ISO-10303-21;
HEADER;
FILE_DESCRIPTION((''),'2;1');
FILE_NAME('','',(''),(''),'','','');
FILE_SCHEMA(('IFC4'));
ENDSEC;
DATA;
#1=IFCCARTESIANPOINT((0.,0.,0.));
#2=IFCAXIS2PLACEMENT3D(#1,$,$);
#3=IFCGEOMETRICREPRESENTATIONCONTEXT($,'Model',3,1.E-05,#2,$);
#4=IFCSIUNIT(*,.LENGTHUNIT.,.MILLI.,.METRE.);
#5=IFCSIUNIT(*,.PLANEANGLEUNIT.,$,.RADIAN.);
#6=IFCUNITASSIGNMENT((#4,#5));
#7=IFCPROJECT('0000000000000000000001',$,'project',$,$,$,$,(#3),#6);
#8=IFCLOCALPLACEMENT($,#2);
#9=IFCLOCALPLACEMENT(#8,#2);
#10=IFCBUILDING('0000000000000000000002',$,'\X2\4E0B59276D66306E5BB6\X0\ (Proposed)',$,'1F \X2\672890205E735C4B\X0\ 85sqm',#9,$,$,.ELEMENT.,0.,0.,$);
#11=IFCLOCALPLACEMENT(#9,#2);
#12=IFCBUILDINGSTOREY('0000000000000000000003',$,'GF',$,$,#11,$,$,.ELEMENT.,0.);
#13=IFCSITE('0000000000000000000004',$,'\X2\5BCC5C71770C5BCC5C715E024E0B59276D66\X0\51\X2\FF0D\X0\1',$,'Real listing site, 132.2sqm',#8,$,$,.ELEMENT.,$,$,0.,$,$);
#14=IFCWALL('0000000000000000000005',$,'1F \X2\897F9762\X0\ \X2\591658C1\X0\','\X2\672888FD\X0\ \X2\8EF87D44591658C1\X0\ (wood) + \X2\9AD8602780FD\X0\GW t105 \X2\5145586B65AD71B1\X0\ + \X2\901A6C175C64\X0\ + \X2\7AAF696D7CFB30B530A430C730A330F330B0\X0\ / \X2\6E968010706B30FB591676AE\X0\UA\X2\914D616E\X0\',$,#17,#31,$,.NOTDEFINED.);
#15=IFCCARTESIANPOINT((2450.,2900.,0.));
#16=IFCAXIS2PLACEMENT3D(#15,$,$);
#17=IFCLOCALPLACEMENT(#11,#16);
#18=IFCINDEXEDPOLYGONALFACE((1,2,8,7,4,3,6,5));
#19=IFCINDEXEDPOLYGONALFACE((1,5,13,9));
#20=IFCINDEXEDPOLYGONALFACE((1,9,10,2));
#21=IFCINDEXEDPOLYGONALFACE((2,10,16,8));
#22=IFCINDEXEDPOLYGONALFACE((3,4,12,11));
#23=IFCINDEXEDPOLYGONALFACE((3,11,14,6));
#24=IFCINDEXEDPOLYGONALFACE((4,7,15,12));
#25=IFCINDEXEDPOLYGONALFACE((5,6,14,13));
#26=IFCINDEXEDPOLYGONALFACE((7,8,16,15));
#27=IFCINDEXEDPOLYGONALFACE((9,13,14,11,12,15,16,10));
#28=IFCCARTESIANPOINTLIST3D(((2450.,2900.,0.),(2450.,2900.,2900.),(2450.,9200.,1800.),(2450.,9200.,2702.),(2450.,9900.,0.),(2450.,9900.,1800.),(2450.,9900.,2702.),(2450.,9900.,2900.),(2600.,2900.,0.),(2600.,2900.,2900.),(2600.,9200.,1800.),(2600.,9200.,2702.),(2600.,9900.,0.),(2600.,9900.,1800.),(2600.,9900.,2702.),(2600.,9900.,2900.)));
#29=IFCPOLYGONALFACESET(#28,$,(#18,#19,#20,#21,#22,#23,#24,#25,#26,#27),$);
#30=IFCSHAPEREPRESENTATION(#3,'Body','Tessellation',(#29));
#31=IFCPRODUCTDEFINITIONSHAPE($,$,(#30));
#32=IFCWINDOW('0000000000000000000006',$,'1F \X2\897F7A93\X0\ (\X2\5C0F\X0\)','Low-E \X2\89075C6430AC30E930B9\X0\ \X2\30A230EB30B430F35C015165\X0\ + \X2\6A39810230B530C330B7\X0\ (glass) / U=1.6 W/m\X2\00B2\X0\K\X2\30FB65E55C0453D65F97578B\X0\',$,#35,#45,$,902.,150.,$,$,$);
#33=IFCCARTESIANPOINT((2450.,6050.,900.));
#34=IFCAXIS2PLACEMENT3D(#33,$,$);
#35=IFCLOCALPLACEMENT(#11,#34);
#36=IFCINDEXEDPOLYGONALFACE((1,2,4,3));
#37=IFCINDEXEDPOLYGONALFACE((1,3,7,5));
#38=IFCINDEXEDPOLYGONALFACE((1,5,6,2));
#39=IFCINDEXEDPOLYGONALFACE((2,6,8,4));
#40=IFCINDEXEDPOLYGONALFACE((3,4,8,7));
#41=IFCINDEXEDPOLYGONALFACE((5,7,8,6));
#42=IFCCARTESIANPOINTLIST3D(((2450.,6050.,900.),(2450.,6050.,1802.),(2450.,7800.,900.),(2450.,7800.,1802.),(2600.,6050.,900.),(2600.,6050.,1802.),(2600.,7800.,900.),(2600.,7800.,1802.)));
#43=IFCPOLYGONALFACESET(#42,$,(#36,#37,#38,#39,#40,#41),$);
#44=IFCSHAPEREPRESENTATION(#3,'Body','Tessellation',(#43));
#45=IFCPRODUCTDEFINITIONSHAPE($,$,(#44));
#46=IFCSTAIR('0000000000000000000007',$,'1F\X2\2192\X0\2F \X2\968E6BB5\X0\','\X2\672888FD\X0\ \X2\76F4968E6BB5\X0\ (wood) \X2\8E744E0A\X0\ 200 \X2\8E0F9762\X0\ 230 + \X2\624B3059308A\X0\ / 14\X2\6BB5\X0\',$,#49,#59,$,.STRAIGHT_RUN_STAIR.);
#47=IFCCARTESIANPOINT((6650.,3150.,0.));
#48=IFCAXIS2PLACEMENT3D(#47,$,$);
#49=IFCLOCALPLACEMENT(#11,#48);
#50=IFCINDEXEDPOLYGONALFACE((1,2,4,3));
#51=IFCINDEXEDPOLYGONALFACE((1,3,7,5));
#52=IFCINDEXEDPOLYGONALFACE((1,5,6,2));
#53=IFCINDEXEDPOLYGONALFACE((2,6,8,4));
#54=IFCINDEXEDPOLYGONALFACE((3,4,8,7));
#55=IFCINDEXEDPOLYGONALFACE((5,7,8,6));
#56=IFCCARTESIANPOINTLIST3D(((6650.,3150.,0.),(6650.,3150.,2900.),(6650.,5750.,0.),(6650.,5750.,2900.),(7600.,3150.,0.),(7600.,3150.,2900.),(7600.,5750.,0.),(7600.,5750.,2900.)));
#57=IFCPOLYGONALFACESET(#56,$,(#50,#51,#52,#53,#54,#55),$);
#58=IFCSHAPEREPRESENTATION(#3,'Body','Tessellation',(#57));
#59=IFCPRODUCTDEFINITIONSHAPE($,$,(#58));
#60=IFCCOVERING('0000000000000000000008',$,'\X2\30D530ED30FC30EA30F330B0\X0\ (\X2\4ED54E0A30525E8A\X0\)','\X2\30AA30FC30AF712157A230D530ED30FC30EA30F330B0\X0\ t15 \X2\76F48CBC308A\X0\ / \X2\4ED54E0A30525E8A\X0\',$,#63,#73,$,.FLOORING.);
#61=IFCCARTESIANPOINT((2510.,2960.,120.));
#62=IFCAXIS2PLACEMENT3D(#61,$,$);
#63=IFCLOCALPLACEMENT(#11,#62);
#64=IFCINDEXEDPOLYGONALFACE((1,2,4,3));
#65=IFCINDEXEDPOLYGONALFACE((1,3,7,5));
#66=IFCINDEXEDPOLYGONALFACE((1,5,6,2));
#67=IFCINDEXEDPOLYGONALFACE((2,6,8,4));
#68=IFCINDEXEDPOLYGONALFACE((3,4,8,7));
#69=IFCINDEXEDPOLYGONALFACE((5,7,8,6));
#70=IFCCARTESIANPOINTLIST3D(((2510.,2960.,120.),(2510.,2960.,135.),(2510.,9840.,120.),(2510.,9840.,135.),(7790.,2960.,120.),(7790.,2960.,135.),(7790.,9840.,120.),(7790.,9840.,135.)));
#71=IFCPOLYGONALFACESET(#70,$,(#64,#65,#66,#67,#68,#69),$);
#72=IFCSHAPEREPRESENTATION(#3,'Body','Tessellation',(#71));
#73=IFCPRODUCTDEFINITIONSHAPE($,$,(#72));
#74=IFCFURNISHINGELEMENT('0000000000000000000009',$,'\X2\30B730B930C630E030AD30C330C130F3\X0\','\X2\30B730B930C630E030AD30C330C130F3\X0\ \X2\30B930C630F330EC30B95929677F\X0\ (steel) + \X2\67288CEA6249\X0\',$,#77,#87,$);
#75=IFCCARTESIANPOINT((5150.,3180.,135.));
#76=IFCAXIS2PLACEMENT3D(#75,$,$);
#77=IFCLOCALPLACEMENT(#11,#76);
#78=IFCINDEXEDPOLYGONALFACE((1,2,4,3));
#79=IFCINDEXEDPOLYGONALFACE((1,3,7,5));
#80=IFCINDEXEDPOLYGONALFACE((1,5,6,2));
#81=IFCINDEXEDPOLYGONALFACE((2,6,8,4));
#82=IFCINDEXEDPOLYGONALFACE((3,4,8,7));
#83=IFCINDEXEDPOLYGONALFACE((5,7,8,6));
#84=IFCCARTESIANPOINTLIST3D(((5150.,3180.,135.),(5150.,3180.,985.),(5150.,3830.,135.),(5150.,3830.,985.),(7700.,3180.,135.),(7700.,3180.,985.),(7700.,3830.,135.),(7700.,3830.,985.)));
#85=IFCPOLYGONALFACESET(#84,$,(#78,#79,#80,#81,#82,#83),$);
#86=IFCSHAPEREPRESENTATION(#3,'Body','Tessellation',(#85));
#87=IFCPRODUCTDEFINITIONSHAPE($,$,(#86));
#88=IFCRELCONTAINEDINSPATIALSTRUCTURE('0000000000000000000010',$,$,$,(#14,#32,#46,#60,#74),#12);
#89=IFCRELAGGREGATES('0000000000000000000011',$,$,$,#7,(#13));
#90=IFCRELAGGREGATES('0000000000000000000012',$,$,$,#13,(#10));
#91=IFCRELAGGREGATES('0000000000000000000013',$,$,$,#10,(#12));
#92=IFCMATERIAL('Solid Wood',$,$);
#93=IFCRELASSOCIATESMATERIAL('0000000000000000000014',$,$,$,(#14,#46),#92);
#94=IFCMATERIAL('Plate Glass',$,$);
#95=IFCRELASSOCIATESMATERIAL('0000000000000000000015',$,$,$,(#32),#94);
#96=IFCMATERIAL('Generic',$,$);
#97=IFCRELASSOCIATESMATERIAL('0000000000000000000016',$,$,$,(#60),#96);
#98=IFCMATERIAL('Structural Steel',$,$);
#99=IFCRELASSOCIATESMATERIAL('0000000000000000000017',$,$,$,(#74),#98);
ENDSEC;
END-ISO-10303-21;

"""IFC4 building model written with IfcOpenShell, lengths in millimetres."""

from ifc_helpers import new_model, si_unit, frame, frame_2d, origin, place, context, project, spatial, rectangle, extrude, material, element, fill, save


model = new_model("IFC4")

# Units and contexts
model_context = context("Model", 3, precision=1e-05, world=origin())
ifc_project = project(units=[si_unit("LENGTHUNIT", "METRE", prefix="MILLI"), si_unit("PLANEANGLEUNIT", "RADIAN")], contexts=[model_context])

# Site, building, storey
site_placement = place(None, origin())
site = spatial("IfcSite", under=ifc_project, at=site_placement, Name="富山県富山市下大浦51－1", ObjectType="Real listing site, 132.2sqm", CompositionType="ELEMENT", RefElevation=0.0)
building_placement = place(site_placement, origin())
building = spatial("IfcBuilding", under=site, at=building_placement, Name="下大浦の家 (Proposed)", ObjectType="1F 木造平屋 85sqm", CompositionType="ELEMENT", ElevationOfRefHeight=0.0, ElevationOfTerrain=0.0)
storey_placement = place(building_placement, origin())
storey = spatial("IfcBuildingStorey", under=building, at=storey_placement, Name="GF", CompositionType="ELEMENT", Elevation=0.0)

# Shared definitions
ifc_material_1 = material(Name="Solid Wood")
ifc_material_2 = material(Name="Generic")

# Shared definitions
ifc_material_3 = material(Name="Plate Glass")

# Wall, opening, window
wall_1_placement = place(storey_placement, frame((2450.0, 2900.0, 0.0)))
wall_1 = element("IfcWall", 1, at=wall_1_placement, inside=storey, material=ifc_material_1, Name="1F 西面 外壁", Description="木製 軸組外壁 (wood) + 高性能GW t105 充填断熱 + 通気層 + 窯業系サイディング / 準耐火・外皮UA配慮", PredefinedType="NOTDEFINED", context=model_context, shape_type="SweptSolid", body=[
    extrude(rectangle(XDim=150.0, YDim=7000.0, at=frame_2d((75.0, 3500.0))), frame((2450.0, 2900.0, 0.0)), (0.0, 0.0, 1.0), 2900.0),
])
opening_1_placement = place(storey_placement, frame((2450.0, 6050.0, 900.0)))
opening_1 = element("IfcOpeningElement", 2, at=opening_1_placement, cuts=wall_1, PredefinedType="NOTDEFINED", context=model_context, shape_type="SweptSolid", body=[
    extrude(rectangle(XDim=150.0, YDim=1750.0, at=frame_2d((75.0, 875.0))), frame((2450.0, 6050.0, 900.0)), (0.0, 0.0, 1.0), 902.0),
])
window_1_placement = place(storey_placement, frame((2450.0, 6050.0, 900.0)))
window_1 = element("IfcWindow", 3, at=window_1_placement, inside=storey, material=ifc_material_3, Name="1F 西窓 (小)", Description="Low-E 複層ガラス アルゴン封入 + 樹脂サッシ (glass) / U=1.6 W/m²K・日射取得型", OverallHeight=902.0, OverallWidth=150.0, context=model_context, shape_type="SweptSolid", body=[
    extrude(rectangle(XDim=150.0, YDim=1750.0, at=frame_2d((75.0, 875.0))), frame((2450.0, 6050.0, 900.0)), (0.0, 0.0, 1.0), 902.0),
])
fill(opening_1, window_1)

# Stair
stair_placement = place(storey_placement, frame((6650.0, 3150.0, 0.0)))
element("IfcStair", 4, at=stair_placement, inside=storey, material=ifc_material_1, Name="1F→2F 階段", Description="木製 直階段 (wood) 蹴上 200 踏面 230 + 手すり / 14段", PredefinedType="STRAIGHT_RUN_STAIR", context=model_context, shape_type="SweptSolid", body=[
    extrude(rectangle(XDim=950.0, YDim=2600.0, at=frame_2d((475.0, 1300.0))), frame((6650.0, 3150.0, 0.0)), (0.0, 0.0, 1.0), 2900.0),
])

# Covering
covering_placement = place(storey_placement, frame((2510.0, 2960.0, 120.0)))
element("IfcCovering", 5, at=covering_placement, inside=storey, material=ifc_material_2, Name="フローリング (仕上げ床)", Description="オーク無垢フローリング t15 直貼り / 仕上げ床", PredefinedType="FLOORING", context=model_context, shape_type="SweptSolid", body=[
    extrude(rectangle(XDim=5280.0, YDim=6880.0, at=frame_2d((2640.0, 3440.0))), frame((2510.0, 2960.0, 120.0)), (0.0, 0.0, 1.0), 15.0),
])

# Furnishing element
ifc_material_4 = material(Name="Structural Steel")
furnishing_placement = place(storey_placement, frame((5150.0, 3180.0, 135.0)))
element("IfcFurnishingElement", 6, at=furnishing_placement, inside=storey, material=ifc_material_4, Name="システムキッチン", Description="システムキッチン ステンレス天板 (steel) + 木質扉", context=model_context, shape_type="SweptSolid", body=[
    extrude(rectangle(XDim=2550.0, YDim=650.0, at=frame_2d((1275.0, 325.0))), frame((5150.0, 3180.0, 135.0)), (0.0, 0.0, 1.0), 850.0),
])

save(model, "model.ifc")
